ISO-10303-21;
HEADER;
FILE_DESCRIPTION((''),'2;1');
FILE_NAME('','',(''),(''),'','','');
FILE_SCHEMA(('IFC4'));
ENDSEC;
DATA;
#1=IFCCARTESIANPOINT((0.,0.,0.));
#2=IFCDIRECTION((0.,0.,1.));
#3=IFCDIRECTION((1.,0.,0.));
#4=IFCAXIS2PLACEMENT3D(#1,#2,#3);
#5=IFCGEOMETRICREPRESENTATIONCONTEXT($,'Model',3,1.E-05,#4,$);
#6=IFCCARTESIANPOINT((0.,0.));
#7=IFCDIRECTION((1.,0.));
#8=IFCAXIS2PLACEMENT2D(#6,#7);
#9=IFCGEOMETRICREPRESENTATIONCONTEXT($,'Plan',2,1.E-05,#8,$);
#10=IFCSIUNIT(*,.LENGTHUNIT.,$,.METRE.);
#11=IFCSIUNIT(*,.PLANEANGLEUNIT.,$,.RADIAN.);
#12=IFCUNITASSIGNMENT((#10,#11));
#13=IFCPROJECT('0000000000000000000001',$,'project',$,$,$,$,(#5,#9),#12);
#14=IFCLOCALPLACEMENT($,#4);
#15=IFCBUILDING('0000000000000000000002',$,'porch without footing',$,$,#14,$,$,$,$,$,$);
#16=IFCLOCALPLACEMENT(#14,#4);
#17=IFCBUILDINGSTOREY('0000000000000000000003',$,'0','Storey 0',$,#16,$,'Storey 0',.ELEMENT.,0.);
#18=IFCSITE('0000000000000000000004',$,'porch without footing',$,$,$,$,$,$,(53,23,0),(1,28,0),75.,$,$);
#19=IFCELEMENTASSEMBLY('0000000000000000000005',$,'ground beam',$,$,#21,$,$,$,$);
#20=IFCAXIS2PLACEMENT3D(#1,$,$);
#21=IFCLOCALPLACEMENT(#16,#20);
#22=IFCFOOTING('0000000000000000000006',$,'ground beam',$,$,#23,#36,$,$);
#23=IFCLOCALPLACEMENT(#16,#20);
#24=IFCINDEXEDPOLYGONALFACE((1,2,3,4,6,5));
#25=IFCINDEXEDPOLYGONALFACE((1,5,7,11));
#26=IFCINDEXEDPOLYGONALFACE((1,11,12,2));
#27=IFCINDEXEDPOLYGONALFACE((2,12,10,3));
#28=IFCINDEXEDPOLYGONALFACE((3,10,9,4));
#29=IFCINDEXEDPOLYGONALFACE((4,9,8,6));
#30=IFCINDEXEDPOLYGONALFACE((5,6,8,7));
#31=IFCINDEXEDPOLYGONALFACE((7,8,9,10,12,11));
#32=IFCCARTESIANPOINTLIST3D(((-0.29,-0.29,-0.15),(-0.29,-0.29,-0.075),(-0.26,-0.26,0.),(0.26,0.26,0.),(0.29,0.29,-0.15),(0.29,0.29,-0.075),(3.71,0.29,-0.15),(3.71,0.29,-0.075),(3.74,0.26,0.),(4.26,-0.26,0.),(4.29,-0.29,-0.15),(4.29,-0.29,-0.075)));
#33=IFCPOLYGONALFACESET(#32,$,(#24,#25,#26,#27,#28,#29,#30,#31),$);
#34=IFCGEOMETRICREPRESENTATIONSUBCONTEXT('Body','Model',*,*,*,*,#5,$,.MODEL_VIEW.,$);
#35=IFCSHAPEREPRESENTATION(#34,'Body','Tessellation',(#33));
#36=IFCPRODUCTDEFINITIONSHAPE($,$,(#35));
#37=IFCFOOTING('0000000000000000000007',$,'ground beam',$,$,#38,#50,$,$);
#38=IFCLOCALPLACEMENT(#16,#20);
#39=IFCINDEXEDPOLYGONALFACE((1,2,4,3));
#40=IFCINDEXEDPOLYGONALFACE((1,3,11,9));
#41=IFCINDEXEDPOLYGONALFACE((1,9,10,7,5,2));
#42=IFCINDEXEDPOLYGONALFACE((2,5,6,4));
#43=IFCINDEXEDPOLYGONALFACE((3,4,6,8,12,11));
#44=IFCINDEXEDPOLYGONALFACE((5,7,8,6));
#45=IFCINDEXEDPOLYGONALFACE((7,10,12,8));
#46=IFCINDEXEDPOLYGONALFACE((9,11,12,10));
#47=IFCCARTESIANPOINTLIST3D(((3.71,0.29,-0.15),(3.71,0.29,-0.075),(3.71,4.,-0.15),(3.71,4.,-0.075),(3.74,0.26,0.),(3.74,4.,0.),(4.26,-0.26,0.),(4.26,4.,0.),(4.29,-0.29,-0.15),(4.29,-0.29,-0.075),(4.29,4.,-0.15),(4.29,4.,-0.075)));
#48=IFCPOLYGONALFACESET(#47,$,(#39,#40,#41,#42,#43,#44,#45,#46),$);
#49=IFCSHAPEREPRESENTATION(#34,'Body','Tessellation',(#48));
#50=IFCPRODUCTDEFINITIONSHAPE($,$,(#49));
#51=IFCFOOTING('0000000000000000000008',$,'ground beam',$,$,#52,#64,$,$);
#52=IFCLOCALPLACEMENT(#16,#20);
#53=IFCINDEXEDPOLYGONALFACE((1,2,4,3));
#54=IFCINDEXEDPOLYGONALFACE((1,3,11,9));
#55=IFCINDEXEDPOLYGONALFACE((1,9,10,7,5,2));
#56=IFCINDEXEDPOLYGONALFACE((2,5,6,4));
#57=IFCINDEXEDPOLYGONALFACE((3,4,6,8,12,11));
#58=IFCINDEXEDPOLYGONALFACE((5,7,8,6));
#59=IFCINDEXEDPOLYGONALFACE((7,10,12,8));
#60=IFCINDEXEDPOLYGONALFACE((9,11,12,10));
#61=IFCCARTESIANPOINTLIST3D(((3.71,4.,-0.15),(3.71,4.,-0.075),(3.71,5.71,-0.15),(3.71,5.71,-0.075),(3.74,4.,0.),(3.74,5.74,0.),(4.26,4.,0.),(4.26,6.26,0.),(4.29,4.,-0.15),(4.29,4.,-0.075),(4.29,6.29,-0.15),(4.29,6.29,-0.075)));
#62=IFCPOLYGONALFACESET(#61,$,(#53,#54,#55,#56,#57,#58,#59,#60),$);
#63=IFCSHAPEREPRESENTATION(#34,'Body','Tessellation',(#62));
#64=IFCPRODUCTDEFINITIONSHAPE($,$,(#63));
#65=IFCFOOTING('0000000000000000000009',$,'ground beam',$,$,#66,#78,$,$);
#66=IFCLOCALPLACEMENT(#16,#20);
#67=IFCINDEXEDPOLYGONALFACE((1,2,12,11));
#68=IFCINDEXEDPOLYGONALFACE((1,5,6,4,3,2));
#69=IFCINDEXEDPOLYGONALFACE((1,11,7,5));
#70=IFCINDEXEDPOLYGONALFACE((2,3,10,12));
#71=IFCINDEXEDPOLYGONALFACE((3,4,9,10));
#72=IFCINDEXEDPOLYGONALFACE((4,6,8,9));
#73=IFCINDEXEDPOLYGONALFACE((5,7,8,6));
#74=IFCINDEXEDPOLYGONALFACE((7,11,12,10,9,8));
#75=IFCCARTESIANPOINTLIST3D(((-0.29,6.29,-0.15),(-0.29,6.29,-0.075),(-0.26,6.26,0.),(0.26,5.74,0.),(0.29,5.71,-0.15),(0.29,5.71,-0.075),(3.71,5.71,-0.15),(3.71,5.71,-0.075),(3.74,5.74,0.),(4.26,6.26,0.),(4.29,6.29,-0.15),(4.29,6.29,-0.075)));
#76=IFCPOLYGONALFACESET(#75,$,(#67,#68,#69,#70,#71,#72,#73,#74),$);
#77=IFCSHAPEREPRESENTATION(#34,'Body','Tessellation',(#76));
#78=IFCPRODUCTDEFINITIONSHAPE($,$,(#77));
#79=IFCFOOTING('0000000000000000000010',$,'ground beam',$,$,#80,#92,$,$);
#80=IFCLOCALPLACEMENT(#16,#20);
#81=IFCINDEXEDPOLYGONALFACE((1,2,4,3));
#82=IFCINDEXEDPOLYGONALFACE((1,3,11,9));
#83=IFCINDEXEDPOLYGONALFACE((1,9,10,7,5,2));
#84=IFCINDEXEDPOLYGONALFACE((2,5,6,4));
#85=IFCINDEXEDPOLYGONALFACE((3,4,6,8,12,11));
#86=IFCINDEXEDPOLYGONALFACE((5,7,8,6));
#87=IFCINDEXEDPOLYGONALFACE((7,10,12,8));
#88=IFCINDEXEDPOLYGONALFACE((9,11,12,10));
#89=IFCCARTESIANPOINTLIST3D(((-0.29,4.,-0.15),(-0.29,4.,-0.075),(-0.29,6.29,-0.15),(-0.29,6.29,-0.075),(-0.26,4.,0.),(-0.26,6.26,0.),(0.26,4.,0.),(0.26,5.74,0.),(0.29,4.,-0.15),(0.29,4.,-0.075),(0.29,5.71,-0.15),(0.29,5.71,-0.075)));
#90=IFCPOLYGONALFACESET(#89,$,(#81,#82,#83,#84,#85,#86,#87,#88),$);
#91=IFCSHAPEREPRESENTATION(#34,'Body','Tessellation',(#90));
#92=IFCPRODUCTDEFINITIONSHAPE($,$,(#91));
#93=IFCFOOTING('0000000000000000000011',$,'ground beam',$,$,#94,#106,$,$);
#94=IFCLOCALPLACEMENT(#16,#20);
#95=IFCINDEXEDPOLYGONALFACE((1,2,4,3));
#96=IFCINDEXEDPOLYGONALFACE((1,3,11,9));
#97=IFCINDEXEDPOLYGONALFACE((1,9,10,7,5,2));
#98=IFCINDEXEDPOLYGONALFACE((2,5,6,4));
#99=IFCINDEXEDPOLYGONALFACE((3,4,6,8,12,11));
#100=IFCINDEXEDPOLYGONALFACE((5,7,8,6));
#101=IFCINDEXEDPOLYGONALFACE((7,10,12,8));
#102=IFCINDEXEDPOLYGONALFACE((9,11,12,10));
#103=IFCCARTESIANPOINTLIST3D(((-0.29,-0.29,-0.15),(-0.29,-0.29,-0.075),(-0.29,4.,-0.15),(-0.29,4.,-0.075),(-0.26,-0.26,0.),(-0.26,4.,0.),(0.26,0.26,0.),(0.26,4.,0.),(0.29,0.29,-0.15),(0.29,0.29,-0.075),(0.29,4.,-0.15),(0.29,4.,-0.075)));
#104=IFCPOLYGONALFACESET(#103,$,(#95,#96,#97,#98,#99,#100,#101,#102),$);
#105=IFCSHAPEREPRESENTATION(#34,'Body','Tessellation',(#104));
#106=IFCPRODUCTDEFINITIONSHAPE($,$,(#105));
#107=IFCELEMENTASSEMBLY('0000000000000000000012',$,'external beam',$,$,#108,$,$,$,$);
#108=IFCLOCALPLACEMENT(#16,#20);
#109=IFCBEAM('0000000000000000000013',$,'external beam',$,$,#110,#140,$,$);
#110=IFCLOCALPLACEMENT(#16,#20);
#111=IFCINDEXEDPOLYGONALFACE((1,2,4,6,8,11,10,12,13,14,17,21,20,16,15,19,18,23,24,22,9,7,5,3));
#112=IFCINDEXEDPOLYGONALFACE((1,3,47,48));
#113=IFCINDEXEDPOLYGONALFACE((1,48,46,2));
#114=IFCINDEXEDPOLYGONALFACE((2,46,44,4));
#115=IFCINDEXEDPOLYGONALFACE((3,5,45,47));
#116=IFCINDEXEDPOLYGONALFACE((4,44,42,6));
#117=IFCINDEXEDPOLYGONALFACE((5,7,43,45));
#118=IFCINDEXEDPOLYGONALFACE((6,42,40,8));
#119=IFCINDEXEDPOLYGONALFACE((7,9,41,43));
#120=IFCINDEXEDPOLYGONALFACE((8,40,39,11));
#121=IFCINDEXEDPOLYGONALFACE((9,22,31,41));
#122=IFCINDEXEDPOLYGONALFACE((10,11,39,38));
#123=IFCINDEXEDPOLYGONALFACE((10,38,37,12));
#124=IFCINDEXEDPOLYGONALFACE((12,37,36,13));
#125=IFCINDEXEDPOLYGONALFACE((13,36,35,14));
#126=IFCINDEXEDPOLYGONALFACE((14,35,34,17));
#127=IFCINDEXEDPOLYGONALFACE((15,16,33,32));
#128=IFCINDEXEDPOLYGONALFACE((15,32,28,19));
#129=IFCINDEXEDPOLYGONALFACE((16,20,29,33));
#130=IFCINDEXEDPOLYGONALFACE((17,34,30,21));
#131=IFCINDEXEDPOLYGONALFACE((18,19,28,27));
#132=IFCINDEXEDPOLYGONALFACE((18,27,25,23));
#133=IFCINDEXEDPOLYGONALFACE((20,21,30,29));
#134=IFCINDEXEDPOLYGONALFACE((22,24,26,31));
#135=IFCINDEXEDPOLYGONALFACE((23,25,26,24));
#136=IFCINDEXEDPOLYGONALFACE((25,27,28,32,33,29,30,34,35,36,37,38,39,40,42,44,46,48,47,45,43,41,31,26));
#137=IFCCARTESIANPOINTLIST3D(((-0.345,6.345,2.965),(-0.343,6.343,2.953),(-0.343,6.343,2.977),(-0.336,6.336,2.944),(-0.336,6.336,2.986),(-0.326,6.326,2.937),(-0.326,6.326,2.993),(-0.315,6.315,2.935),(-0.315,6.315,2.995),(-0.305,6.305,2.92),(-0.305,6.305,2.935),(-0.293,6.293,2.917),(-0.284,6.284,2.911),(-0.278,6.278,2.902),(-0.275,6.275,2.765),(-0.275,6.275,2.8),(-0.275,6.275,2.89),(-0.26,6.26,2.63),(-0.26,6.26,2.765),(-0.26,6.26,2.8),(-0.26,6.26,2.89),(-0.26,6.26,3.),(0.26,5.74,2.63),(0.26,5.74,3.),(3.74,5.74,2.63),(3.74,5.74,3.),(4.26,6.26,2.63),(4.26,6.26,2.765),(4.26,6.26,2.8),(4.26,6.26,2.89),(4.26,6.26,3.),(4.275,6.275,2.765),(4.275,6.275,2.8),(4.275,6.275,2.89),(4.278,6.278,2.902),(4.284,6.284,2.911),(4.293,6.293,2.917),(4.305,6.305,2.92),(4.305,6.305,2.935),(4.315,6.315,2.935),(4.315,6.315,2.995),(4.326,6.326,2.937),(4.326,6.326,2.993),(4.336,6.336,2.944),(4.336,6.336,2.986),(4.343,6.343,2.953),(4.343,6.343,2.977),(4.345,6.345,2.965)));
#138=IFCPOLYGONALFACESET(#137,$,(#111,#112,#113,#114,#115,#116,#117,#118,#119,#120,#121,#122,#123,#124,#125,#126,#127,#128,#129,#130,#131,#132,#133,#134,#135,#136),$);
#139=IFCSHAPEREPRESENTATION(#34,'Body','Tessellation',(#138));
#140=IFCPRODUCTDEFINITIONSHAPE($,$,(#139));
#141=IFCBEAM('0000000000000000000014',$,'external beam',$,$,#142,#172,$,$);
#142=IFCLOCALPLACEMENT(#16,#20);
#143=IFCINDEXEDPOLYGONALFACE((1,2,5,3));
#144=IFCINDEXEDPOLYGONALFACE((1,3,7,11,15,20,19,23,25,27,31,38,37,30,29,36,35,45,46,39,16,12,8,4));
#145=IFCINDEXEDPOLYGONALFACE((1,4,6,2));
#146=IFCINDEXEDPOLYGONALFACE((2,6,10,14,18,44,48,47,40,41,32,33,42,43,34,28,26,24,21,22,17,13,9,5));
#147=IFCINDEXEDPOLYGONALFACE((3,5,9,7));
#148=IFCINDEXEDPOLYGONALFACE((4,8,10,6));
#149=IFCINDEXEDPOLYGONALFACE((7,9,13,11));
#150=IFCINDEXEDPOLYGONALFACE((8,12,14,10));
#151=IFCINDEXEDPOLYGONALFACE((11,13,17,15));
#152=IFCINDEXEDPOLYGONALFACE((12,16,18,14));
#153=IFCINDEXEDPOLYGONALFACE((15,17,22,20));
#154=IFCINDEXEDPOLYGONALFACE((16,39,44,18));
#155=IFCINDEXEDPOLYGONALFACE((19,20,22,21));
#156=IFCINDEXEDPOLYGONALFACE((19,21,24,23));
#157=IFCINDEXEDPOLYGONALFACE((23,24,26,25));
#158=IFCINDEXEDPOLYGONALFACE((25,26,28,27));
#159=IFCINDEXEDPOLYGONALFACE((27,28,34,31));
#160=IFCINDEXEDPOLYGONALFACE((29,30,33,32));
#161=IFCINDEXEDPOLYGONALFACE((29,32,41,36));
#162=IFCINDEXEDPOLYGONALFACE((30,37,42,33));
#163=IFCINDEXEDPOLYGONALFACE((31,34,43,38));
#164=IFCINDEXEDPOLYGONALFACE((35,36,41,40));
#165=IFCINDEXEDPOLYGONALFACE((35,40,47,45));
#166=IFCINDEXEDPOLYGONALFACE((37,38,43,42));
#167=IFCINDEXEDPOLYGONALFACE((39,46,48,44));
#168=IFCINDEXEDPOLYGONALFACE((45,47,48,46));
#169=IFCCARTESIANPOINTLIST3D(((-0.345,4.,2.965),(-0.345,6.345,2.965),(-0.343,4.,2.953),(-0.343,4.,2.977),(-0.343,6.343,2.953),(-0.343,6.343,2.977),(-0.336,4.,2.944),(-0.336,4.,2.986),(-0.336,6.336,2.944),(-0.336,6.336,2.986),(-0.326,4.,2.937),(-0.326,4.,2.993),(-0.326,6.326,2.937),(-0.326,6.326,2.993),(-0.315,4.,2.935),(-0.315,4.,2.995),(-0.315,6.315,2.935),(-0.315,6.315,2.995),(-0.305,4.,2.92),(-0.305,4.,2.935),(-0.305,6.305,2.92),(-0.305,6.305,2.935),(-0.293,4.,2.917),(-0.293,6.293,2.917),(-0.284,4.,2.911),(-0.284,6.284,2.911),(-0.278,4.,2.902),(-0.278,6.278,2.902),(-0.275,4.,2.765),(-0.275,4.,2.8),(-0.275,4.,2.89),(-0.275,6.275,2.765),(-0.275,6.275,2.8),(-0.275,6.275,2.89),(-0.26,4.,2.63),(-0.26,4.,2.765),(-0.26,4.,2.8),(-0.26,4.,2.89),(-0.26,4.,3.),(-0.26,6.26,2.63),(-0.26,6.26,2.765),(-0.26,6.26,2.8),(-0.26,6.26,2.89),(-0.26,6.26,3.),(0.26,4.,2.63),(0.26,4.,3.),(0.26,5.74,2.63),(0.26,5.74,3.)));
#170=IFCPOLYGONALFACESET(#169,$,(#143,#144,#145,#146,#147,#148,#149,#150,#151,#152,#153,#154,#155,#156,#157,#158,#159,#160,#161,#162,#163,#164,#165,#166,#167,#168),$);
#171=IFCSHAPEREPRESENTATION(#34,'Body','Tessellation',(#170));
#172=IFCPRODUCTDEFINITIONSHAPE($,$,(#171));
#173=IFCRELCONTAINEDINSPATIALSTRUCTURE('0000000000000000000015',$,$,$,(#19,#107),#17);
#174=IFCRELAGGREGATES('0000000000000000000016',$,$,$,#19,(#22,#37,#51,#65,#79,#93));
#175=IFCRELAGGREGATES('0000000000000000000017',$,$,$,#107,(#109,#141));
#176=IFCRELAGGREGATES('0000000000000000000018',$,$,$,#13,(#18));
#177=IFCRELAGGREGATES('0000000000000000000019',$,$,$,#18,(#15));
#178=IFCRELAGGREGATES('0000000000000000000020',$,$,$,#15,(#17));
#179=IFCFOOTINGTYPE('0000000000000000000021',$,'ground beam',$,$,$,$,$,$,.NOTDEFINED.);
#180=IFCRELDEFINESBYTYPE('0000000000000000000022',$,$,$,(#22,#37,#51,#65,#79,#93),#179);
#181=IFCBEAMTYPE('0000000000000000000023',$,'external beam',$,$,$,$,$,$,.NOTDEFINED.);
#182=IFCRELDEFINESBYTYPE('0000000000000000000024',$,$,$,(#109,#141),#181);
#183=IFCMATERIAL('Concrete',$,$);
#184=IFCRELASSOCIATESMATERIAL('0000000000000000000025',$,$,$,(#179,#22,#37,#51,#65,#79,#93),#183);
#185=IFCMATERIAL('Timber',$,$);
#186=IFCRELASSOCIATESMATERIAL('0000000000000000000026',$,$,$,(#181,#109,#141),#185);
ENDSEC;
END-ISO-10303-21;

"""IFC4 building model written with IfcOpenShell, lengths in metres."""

from ifc_helpers import new_model, si_unit, frame, origin_with_axes, origin_2d_with_axis, place, context, subcontext, project, spatial, polyline, outline, extrude, clip, halfspace, material, material_profile, profile_set, profile_usage, type_object, element, aggregate, save


model = new_model("IFC4")

# Units and contexts
model_context = context("Model", 3, precision=1e-05, world=origin_with_axes())
plan_context = context("Plan", 2, precision=1e-05, world=origin_2d_with_axis())
body_context = subcontext(model_context, "Body", "Model", "MODEL_VIEW")
ifc_project = project(units=[si_unit("LENGTHUNIT", "METRE"), si_unit("PLANEANGLEUNIT", "RADIAN")], contexts=[model_context, plan_context])

# Site, building, storey
site = spatial("IfcSite", under=ifc_project, Name="porch without footing", RefLatitude=(53, 23, 0), RefLongitude=(1, 28, 0), RefElevation=75.0)
building_placement = place(None, origin_with_axes())
building = spatial("IfcBuilding", under=site, at=building_placement, Name="porch without footing")
storey_placement = place(building_placement, origin_with_axes())
storey = spatial("IfcBuildingStorey", under=building, at=storey_placement, Name="0", Description="Storey 0", LongName="Storey 0", CompositionType="ELEMENT", Elevation=0.0)

# Element assembly, footings
assembly_1_placement = place(storey_placement, origin_with_axes())
assembly_1 = element("IfcElementAssembly", 1, at=assembly_1_placement, inside=storey, Name="ground beam")
ifc_material_1 = material(Name="Concrete")
ifc_material_profile_1 = material_profile(ifc_material_1, outline(polyline([(-0.26, 0.0), (-0.29, -0.075), (-0.29, -0.15), (0.29, -0.15), (0.29, -0.075), (0.26, 0.0), (-0.26, 0.0)])))
ifc_profile_set_1 = profile_set([ifc_material_profile_1])
ifc_profile_usage_1 = profile_usage(ifc_profile_set_1)
footing_type = type_object("IfcFootingType", Name="ground beam", PredefinedType="NOTDEFINED", material=ifc_profile_set_1)
footing_1_placement = place(assembly_1_placement, frame((5.0, 0.0, 0.0), z_axis=(-1.0, 0.0, 0.0), x_axis=(0.0, -1.0, 0.0)))
footing_1 = element("IfcFooting", 2, at=footing_1_placement, type_object=footing_type, material=ifc_profile_usage_1, Name="ground beam", context=body_context, shape_type="Clipping", body=[
    clip(clip(extrude(outline(polyline([(-0.26, 0.0), (-0.29, -0.075), (-0.29, -0.15), (0.29, -0.15), (0.29, -0.075), (0.26, 0.0), (-0.26, 0.0)])), origin_with_axes(), (0.0, 0.0, 1.0), 6.0), halfspace(frame((0.0, 0.0, 1.0), z_axis=(-0.707107, 0.0, -0.707107), x_axis=(0.0, 1.0, 0.0)), False)), halfspace(frame((0.0, 0.0, 5.0), z_axis=(-0.707107, 0.0, 0.707107), x_axis=(0.0, 1.0, 0.0)), False)),
])
ifc_profile_usage_2 = profile_usage(ifc_profile_set_1)
footing_2_placement = place(assembly_1_placement, frame((4.0, 5.0, 0.0), z_axis=(0.0, -1.0, 0.0), x_axis=(1.0, 0.0, 0.0)))
footing_2 = element("IfcFooting", 3, at=footing_2_placement, type_object=footing_type, material=ifc_profile_usage_2, Name="ground beam", context=body_context, shape_type="Clipping", body=[
    clip(clip(extrude(outline(polyline([(-0.26, 0.0), (-0.29, -0.075), (-0.29, -0.15), (0.29, -0.15), (0.29, -0.075), (0.26, 0.0), (-0.26, 0.0)])), origin_with_axes(), (0.0, 0.0, 1.0), 6.0), halfspace(frame((0.0, 0.0, 1.0), z_axis=(0.0, 0.0, -1.0), x_axis=(1.0, 0.0, 0.0)), False)), halfspace(frame((0.0, 0.0, 5.0), z_axis=(-0.707107, 0.0, 0.707107), x_axis=(0.0, 1.0, 0.0)), False)),
])
ifc_profile_usage_3 = profile_usage(ifc_profile_set_1)
footing_3_placement = place(assembly_1_placement, frame((4.0, 7.0, 0.0), z_axis=(0.0, -1.0, 0.0), x_axis=(1.0, 0.0, 0.0)))
footing_3 = element("IfcFooting", 4, at=footing_3_placement, type_object=footing_type, material=ifc_profile_usage_3, Name="ground beam", context=body_context, shape_type="Clipping", body=[
    clip(clip(extrude(outline(polyline([(-0.26, 0.0), (-0.29, -0.075), (-0.29, -0.15), (0.29, -0.15), (0.29, -0.075), (0.26, 0.0), (-0.26, 0.0)])), origin_with_axes(), (0.0, 0.0, 1.0), 4.0), halfspace(frame((0.0, 0.0, 1.0), z_axis=(-0.707107, 0.0, -0.707107), x_axis=(0.0, 1.0, 0.0)), False)), halfspace(frame((0.0, 0.0, 3.0), z_axis=(0.0, 0.0, 1.0), x_axis=(-1.0, 0.0, 0.0)), False)),
])
ifc_profile_usage_4 = profile_usage(ifc_profile_set_1)
footing_4_placement = place(assembly_1_placement, frame((-1.0, 6.0, 0.0), z_axis=(1.0, 0.0, 0.0), x_axis=(0.0, 1.0, 0.0)))
footing_4 = element("IfcFooting", 5, at=footing_4_placement, type_object=footing_type, material=ifc_profile_usage_4, Name="ground beam", context=body_context, shape_type="Clipping", body=[
    clip(clip(extrude(outline(polyline([(-0.26, 0.0), (-0.29, -0.075), (-0.29, -0.15), (0.29, -0.15), (0.29, -0.075), (0.26, 0.0), (-0.26, 0.0)])), origin_with_axes(), (0.0, 0.0, 1.0), 6.0), halfspace(frame((0.0, 0.0, 1.0), z_axis=(-0.707107, 0.0, -0.707107), x_axis=(0.0, 1.0, 0.0)), False)), halfspace(frame((0.0, 0.0, 5.0), z_axis=(-0.707107, 0.0, 0.707107), x_axis=(0.0, 1.0, 0.0)), False)),
])
ifc_profile_usage_5 = profile_usage(ifc_profile_set_1)
footing_5_placement = place(assembly_1_placement, frame((0.0, 3.0, 0.0), z_axis=(0.0, 1.0, 0.0), x_axis=(-1.0, 0.0, 0.0)))
footing_5 = element("IfcFooting", 6, at=footing_5_placement, type_object=footing_type, material=ifc_profile_usage_5, Name="ground beam", context=body_context, shape_type="Clipping", body=[
    clip(clip(extrude(outline(polyline([(-0.26, 0.0), (-0.29, -0.075), (-0.29, -0.15), (0.29, -0.15), (0.29, -0.075), (0.26, 0.0), (-0.26, 0.0)])), origin_with_axes(), (0.0, 0.0, 1.0), 4.0), halfspace(frame((0.0, 0.0, 1.0), z_axis=(0.0, 0.0, -1.0), x_axis=(1.0, 0.0, 0.0)), False)), halfspace(frame((0.0, 0.0, 3.0), z_axis=(-0.707107, 0.0, 0.707107), x_axis=(0.0, 1.0, 0.0)), False)),
])
ifc_profile_usage_6 = profile_usage(ifc_profile_set_1)
footing_6_placement = place(assembly_1_placement, frame((0.0, -1.0, 0.0), z_axis=(0.0, 1.0, 0.0), x_axis=(-1.0, 0.0, 0.0)))
footing_6 = element("IfcFooting", 7, at=footing_6_placement, type_object=footing_type, material=ifc_profile_usage_6, Name="ground beam", context=body_context, shape_type="Clipping", body=[
    clip(clip(extrude(outline(polyline([(-0.26, 0.0), (-0.29, -0.075), (-0.29, -0.15), (0.29, -0.15), (0.29, -0.075), (0.26, 0.0), (-0.26, 0.0)])), origin_with_axes(), (0.0, 0.0, 1.0), 6.0), halfspace(frame((0.0, 0.0, 1.0), z_axis=(-0.707107, 0.0, -0.707107), x_axis=(0.0, 1.0, 0.0)), False)), halfspace(frame((0.0, 0.0, 5.0), z_axis=(0.0, 0.0, 1.0), x_axis=(-1.0, 0.0, 0.0)), False)),
])
aggregate(assembly_1, [footing_1, footing_2, footing_3, footing_4, footing_5, footing_6])

# Element assembly, beams
assembly_2_placement = place(storey_placement, origin_with_axes())
assembly_2 = element("IfcElementAssembly", 8, at=assembly_2_placement, inside=storey, Name="external beam")
ifc_material_2 = material(Name="Timber")
ifc_material_profile_2 = material_profile(ifc_material_2, outline(polyline([(-0.26, 0.0), (-0.26, -0.37), (0.26, -0.37), (0.26, -0.235), (0.275, -0.235), (0.275, -0.2), (0.26, -0.2), (0.26, -0.11), (0.275, -0.11), (0.278, -0.098), (0.284, -0.089), (0.293, -0.083), (0.305, -0.08), (0.305, -0.065), (0.315, -0.065), (0.326, -0.063), (0.336, -0.056), (0.343, -0.047), (0.345, -0.035), (0.343, -0.023), (0.336, -0.014), (0.326, -0.007), (0.315, -0.005), (0.26, 0.0), (-0.26, 0.0)])))
ifc_profile_set_2 = profile_set([ifc_material_profile_2])
beam_type = type_object("IfcBeamType", Name="external beam", PredefinedType="NOTDEFINED", material=ifc_profile_set_2)
ifc_profile_usage_7 = profile_usage(ifc_profile_set_2)
beam_1_placement = place(assembly_2_placement, frame((-1.0, 6.0, 3.0), z_axis=(1.0, 0.0, 0.0), x_axis=(0.0, 1.0, 0.0)))
beam_1 = element("IfcBeam", 9, at=beam_1_placement, type_object=beam_type, material=ifc_profile_usage_7, Name="external beam", context=body_context, shape_type="Clipping", body=[
    clip(clip(extrude(outline(polyline([(-0.26, 0.0), (-0.26, -0.37), (0.26, -0.37), (0.26, -0.235), (0.275, -0.235), (0.275, -0.2), (0.26, -0.2), (0.26, -0.11), (0.275, -0.11), (0.278, -0.098), (0.284, -0.089), (0.293, -0.083), (0.305, -0.08), (0.305, -0.065), (0.315, -0.065), (0.326, -0.063), (0.336, -0.056), (0.343, -0.047), (0.345, -0.035), (0.343, -0.023), (0.336, -0.014), (0.326, -0.007), (0.315, -0.005), (0.26, 0.0), (-0.26, 0.0)])), origin_with_axes(), (0.0, 0.0, 1.0), 6.0), halfspace(frame((0.0, -3.0, 1.0), z_axis=(-0.707107, 0.0, -0.707107), x_axis=(0.0, 1.0, 0.0)), False)), halfspace(frame((0.0, -3.0, 5.0), z_axis=(-0.707107, 0.0, 0.707107), x_axis=(0.0, 1.0, 0.0)), False)),
])
ifc_profile_usage_8 = profile_usage(ifc_profile_set_2)
beam_2_placement = place(assembly_2_placement, frame((0.0, 4.0, 3.0), z_axis=(0.0, 1.0, 0.0), x_axis=(-1.0, 0.0, 0.0)))
beam_2 = element("IfcBeam", 10, at=beam_2_placement, type_object=beam_type, material=ifc_profile_usage_8, Name="external beam", context=body_context, shape_type="Clipping", body=[
    clip(extrude(outline(polyline([(-0.26, 0.0), (-0.26, -0.37), (0.26, -0.37), (0.26, -0.235), (0.275, -0.235), (0.275, -0.2), (0.26, -0.2), (0.26, -0.11), (0.275, -0.11), (0.278, -0.098), (0.284, -0.089), (0.293, -0.083), (0.305, -0.08), (0.305, -0.065), (0.315, -0.065), (0.326, -0.063), (0.336, -0.056), (0.343, -0.047), (0.345, -0.035), (0.343, -0.023), (0.336, -0.014), (0.326, -0.007), (0.315, -0.005), (0.26, 0.0), (-0.26, 0.0)])), origin_with_axes(), (0.0, 0.0, 1.0), 3.0), halfspace(frame((0.0, -3.0, 2.0), z_axis=(-0.707107, 0.0, 0.707107), x_axis=(0.0, 1.0, 0.0)), False)),
])
aggregate(assembly_2, [beam_1, beam_2])

save(model, "model.ifc")
